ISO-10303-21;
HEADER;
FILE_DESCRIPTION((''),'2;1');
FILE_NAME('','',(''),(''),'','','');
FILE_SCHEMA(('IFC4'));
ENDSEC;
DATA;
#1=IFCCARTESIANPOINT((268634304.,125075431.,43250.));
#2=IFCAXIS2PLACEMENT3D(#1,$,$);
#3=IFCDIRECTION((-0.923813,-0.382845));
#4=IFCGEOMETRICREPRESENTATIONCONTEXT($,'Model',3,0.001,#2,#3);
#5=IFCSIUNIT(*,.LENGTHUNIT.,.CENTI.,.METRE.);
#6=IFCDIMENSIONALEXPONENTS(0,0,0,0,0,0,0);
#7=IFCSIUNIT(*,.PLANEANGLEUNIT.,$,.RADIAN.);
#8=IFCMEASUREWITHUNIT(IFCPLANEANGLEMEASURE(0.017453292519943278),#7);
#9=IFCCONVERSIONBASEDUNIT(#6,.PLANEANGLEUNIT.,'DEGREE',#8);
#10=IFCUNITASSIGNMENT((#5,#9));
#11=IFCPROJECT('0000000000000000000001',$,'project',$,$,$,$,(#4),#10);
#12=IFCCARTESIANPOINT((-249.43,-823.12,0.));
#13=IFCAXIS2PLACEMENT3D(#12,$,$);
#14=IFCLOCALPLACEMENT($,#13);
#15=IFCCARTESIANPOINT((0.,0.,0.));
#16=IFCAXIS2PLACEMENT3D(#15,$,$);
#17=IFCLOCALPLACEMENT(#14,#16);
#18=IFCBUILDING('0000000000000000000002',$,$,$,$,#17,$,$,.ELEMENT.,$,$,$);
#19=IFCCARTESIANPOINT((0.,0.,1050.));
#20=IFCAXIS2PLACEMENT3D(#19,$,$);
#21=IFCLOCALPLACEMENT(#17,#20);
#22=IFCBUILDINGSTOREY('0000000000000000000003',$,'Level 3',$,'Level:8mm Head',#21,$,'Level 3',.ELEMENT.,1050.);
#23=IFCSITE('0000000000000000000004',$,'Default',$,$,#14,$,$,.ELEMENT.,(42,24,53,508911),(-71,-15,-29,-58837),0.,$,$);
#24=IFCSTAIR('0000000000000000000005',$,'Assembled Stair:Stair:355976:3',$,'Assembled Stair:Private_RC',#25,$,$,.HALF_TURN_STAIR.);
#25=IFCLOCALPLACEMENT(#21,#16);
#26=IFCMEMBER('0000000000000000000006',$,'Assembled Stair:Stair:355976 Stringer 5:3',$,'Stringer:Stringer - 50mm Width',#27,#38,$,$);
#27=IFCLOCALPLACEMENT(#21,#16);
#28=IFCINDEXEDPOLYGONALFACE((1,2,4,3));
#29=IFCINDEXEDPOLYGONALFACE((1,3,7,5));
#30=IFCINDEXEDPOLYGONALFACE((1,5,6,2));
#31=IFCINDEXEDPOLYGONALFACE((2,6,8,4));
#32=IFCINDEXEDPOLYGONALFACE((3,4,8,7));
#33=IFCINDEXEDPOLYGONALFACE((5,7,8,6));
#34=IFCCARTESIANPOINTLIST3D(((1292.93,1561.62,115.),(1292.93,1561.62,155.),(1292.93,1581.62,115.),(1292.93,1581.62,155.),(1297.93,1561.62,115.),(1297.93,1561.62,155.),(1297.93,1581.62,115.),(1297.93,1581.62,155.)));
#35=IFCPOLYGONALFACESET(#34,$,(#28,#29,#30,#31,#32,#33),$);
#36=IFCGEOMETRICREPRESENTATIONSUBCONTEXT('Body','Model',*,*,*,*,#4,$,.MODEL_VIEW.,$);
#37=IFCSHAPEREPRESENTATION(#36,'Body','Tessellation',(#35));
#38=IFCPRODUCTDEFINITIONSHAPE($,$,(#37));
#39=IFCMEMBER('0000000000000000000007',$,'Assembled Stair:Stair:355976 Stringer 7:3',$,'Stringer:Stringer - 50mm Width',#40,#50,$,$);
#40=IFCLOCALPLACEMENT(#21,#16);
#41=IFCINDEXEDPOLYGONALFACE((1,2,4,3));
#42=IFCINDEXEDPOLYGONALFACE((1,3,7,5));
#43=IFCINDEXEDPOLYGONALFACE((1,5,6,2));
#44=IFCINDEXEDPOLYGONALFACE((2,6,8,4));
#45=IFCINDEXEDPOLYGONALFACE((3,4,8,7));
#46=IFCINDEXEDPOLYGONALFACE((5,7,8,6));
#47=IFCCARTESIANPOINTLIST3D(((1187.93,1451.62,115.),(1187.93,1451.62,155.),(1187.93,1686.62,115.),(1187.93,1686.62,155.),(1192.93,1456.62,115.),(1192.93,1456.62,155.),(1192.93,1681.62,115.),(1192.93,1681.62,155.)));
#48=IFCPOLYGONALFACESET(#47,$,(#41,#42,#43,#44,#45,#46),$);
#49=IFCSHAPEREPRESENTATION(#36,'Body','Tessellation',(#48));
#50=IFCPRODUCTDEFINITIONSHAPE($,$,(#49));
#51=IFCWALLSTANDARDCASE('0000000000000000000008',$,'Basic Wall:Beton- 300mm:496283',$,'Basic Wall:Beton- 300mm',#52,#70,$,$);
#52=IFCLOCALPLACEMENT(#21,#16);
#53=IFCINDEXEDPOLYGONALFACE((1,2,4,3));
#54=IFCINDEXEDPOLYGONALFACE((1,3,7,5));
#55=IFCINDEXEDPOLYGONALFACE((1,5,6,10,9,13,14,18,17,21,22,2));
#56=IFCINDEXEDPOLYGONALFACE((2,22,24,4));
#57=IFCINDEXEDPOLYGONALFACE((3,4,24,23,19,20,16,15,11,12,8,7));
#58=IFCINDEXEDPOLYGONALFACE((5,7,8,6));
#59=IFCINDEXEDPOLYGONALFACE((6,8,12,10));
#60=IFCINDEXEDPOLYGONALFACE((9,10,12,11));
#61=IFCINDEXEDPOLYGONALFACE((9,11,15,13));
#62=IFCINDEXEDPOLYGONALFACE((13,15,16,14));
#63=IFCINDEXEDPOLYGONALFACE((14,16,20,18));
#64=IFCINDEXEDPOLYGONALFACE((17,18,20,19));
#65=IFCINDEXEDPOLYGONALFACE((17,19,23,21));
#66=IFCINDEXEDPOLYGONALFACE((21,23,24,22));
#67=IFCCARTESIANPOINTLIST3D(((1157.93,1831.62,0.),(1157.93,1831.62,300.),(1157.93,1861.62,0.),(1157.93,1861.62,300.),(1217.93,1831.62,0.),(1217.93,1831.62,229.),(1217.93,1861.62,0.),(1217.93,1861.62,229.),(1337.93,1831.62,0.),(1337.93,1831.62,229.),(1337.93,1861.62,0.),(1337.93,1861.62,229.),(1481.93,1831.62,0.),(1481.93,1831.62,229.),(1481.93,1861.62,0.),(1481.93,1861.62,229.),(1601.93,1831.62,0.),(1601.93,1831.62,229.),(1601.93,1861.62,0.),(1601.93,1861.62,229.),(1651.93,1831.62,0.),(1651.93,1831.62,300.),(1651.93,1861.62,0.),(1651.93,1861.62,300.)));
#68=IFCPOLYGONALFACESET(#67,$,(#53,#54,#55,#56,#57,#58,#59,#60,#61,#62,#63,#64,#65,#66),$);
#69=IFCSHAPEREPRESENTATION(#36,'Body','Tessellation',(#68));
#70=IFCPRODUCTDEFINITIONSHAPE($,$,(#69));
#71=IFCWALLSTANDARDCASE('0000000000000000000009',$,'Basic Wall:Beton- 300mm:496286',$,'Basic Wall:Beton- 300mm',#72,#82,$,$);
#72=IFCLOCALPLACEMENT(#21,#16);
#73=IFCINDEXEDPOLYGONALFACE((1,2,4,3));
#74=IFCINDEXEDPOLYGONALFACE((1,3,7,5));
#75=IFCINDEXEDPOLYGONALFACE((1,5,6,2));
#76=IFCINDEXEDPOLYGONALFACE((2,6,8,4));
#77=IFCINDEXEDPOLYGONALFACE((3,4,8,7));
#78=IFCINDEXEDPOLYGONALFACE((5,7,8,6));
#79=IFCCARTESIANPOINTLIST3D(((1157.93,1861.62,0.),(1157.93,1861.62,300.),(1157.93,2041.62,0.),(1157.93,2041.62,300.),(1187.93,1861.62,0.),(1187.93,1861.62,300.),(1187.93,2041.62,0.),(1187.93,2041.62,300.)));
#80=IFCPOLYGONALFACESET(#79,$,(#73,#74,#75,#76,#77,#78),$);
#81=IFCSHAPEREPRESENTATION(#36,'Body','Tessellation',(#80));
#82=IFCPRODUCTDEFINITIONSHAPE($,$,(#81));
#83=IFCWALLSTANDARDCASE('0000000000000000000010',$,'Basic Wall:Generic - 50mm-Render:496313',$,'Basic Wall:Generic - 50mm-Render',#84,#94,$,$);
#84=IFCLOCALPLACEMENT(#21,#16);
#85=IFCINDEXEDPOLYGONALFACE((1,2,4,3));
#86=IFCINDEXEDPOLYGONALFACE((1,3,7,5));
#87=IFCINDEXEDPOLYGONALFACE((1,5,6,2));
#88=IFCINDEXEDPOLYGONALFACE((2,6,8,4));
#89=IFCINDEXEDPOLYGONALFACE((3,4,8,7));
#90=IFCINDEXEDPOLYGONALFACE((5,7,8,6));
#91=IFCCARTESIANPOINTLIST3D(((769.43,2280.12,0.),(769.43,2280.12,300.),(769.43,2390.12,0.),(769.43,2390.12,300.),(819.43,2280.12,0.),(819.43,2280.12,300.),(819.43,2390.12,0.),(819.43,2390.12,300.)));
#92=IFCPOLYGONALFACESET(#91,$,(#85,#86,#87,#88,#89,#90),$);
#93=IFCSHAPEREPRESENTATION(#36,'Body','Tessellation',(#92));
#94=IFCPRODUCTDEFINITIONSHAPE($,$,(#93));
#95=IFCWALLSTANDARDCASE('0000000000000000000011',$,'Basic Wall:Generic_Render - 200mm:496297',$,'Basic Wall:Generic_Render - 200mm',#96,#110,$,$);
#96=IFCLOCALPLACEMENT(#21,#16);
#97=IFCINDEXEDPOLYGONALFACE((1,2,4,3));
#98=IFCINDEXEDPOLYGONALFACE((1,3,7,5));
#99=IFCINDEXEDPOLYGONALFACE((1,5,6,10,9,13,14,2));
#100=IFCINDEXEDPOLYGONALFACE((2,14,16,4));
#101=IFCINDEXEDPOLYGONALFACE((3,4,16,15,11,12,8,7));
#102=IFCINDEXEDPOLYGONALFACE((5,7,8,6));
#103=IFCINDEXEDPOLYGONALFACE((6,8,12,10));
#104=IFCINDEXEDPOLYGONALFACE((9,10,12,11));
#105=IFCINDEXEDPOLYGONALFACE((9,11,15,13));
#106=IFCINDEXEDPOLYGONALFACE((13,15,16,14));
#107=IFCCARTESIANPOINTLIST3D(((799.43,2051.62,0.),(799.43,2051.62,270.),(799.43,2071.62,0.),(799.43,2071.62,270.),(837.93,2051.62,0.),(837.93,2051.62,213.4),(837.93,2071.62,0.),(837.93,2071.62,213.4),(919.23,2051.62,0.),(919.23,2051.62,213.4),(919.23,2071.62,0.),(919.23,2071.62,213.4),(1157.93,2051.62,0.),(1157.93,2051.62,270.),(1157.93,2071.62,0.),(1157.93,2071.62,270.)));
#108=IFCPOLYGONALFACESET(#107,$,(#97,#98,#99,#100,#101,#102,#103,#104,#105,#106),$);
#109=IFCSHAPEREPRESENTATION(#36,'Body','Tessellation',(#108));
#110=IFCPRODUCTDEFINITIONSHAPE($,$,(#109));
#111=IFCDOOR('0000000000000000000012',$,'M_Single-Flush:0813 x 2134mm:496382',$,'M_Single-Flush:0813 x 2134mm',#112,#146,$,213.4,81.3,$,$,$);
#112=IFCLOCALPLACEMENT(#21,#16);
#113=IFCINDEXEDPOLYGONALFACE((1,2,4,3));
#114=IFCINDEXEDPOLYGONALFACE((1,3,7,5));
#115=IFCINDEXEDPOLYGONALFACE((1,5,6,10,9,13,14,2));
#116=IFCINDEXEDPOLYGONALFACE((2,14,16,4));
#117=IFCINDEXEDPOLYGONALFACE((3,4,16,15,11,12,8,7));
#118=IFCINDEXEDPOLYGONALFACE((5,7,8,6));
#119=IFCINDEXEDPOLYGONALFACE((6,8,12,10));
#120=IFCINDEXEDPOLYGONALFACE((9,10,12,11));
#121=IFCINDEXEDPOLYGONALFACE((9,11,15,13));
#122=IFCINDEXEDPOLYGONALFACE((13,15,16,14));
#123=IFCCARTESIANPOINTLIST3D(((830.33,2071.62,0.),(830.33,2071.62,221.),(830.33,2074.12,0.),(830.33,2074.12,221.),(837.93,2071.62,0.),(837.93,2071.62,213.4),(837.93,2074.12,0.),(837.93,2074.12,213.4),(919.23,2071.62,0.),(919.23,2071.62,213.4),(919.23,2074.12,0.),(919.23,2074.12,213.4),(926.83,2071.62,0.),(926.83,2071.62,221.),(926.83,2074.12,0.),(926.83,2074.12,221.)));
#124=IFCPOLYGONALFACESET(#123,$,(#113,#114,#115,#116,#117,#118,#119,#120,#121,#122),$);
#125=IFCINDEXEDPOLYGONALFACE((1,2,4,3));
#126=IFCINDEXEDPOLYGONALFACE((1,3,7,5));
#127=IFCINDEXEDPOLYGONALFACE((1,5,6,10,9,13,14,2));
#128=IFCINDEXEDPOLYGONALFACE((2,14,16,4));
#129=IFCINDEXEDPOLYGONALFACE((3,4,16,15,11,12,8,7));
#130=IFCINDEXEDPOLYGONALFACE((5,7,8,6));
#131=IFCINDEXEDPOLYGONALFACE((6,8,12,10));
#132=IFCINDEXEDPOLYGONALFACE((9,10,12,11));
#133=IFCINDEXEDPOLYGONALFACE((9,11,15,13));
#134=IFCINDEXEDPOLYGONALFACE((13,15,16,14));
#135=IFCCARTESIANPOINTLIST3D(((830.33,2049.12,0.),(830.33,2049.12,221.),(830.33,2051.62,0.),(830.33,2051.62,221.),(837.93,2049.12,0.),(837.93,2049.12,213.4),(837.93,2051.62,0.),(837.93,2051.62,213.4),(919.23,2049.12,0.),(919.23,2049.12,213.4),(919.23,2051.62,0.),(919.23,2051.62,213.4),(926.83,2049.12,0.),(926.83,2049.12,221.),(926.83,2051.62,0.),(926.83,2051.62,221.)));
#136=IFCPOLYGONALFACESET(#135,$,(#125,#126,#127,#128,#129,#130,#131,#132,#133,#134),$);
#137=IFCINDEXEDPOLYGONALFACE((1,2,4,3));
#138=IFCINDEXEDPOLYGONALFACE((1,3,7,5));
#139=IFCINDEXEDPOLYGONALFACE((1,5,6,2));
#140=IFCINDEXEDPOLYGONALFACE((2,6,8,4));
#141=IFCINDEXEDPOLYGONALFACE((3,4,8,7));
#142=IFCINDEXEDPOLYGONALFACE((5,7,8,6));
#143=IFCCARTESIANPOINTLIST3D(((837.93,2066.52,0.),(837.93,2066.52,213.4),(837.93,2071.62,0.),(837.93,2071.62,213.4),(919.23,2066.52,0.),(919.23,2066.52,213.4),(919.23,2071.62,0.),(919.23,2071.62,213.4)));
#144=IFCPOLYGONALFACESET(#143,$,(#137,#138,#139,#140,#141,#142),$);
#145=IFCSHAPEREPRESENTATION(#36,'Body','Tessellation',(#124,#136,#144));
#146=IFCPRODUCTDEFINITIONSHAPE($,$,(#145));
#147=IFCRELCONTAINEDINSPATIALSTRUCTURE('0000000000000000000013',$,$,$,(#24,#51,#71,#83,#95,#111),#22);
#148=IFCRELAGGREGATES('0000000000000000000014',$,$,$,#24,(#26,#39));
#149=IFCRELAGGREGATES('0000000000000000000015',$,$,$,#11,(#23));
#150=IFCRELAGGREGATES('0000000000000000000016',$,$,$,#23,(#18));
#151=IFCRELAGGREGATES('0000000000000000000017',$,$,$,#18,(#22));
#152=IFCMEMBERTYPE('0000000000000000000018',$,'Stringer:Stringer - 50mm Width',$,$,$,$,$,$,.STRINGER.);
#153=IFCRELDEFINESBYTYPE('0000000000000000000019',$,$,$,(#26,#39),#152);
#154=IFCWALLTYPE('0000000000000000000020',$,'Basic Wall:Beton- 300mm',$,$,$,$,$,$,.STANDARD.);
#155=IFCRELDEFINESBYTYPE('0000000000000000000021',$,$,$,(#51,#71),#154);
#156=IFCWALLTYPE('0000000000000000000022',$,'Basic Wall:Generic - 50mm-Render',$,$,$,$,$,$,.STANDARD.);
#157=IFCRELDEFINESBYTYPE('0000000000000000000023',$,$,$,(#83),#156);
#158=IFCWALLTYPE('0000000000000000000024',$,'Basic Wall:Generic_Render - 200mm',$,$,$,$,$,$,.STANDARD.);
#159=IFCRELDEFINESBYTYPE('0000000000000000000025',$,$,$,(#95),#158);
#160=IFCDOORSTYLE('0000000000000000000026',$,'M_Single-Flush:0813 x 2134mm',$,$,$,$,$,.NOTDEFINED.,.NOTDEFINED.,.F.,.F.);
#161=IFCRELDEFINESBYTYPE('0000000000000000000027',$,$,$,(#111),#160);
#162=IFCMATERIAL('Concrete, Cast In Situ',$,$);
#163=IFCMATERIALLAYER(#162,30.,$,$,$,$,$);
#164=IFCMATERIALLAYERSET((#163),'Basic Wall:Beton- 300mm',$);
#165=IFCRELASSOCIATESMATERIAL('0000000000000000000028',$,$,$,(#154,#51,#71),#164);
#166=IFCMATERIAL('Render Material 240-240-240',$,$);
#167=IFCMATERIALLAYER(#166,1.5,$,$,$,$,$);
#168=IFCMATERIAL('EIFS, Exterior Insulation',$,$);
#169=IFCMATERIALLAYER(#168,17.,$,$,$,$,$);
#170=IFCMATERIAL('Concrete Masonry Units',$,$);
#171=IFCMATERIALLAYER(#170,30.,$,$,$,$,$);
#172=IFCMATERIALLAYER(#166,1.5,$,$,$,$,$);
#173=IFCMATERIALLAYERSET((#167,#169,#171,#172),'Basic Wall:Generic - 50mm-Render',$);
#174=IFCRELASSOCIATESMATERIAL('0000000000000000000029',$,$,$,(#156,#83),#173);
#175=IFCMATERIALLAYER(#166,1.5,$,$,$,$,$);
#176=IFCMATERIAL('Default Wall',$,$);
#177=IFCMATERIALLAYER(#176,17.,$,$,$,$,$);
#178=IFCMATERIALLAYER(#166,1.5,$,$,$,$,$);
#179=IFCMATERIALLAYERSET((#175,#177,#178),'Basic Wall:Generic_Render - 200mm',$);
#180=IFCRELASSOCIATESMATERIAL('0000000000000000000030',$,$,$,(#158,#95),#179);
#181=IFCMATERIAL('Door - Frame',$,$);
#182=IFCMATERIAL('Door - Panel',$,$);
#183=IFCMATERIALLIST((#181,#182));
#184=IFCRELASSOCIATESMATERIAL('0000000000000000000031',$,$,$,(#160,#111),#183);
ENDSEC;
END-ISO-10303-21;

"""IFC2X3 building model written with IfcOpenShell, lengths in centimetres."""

from ifc_helpers import new_model, entity, si_unit, converted_unit, direction, frame, frame_2d, origin, place, context, subcontext, project, spatial, polyline, rectangle, outline, extrude, source, transform, mapped, material, material_list, layer, layer_set, layer_usage, type_object, type_shapes, element, fill, aggregate, save


model = new_model("IFC2X3")

# Units and contexts
model_context = context("Model", 3, precision=0.001, world=frame((268634304.0, 125075431.0, 43250.0)), true_north=direction((-0.923813, -0.382845)))
body_context = subcontext(model_context, "Body", "Model", "MODEL_VIEW")
ifc_project = project(units=[si_unit("LENGTHUNIT", "METRE", prefix="CENTI"), converted_unit("PLANEANGLEUNIT", "DEGREE", entity("IfcPlaneAngleMeasure", 0.017453292519943278), si_unit("PLANEANGLEUNIT", "RADIAN"), dimensions=[0, 0, 0, 0, 0, 0, 0])], contexts=[model_context])

# Site, building, storey
site_placement = place(None, frame((-249.43, -823.12, 0.0)))
site = spatial("IfcSite", under=ifc_project, at=site_placement, Name="Default", CompositionType="ELEMENT", RefLatitude=(42, 24, 53, 508911), RefLongitude=(-71, -15, -29, -58837), RefElevation=0.0)
building_placement = place(site_placement, origin())
building = spatial("IfcBuilding", under=site, at=building_placement, CompositionType="ELEMENT")
storey_placement = place(building_placement, frame((0.0, 0.0, 1050.0)))
storey = spatial("IfcBuildingStorey", under=building, at=storey_placement, Name="Level 3", ObjectType="Level:8mm Head", LongName="Level 3", CompositionType="ELEMENT", Elevation=1050.0)

# Stair, members
stair_placement = place(storey_placement, origin())
stair = element("IfcStair", 1, at=stair_placement, inside=storey, Name="Assembled Stair:Stair:355976:3", ObjectType="Assembled Stair:Private_RC", ShapeType="HALF_TURN_STAIR")
member_type = type_object("IfcMemberType", Name="Stringer:Stringer - 50mm Width", PredefinedType="STRINGER")
member_1_placement = place(stair_placement, frame((1292.93, 1561.62, 115.0)))
member_1 = element("IfcMember", 2, at=member_1_placement, type_object=member_type, Name="Assembled Stair:Stair:355976 Stringer 5:3", ObjectType="Stringer:Stringer - 50mm Width", context=body_context, shape_type="SweptSolid", body=[
    extrude(rectangle(XDim=20.0, YDim=5.0, at=frame_2d((0.0, 0.0), x_axis=(1.0, 0.0))), frame((2.5, 10.0, 0.0), z_axis=(0.0, 0.0, 1.0), x_axis=(0.0, 1.0, 0.0)), (0.0, 0.0, 1.0), 40.0),
])
member_2_placement = place(stair_placement, frame((1187.93, 1451.62, 115.0)))
member_2 = element("IfcMember", 3, at=member_2_placement, type_object=member_type, Name="Assembled Stair:Stair:355976 Stringer 7:3", ObjectType="Stringer:Stringer - 50mm Width", context=body_context, shape_type="SweptSolid", body=[
    extrude(outline(polyline([(-117.5, -2.5), (117.5, -2.5), (112.5, 2.5), (-112.5, 2.5), (-117.5, -2.5)])), frame((2.5, 117.5, 0.0), z_axis=(0.0, 0.0, 1.0), x_axis=(0.0, -1.0, 0.0)), (0.0, 0.0, 1.0), 40.0),
])

# Wall, openings
ifc_material_1 = material(Name="Concrete, Cast In Situ")
ifc_layer_1 = layer(ifc_material_1, 30.0)
ifc_layer_set_1 = layer_set([ifc_layer_1], Name="Basic Wall:Beton- 300mm")
ifc_layer_usage_1 = layer_usage(ifc_layer_set_1, "AXIS2", "NEGATIVE", 15.0)
wall_type_1 = type_object("IfcWallType", Name="Basic Wall:Beton- 300mm", PredefinedType="STANDARD", material=ifc_layer_set_1)
wall_1_placement = place(storey_placement, frame((1157.93, 1846.62, 0.0)))
wall_1 = element("IfcWallStandardCase", 4, at=wall_1_placement, inside=storey, type_object=wall_type_1, material=ifc_layer_usage_1, Name="Basic Wall:Beton- 300mm:496283", ObjectType="Basic Wall:Beton- 300mm", context=body_context, shape_type="SweptSolid", body=[
    extrude(rectangle(XDim=494.0, YDim=30.0, at=frame_2d((247.0, 0.0), x_axis=(-1.0, 0.0))), origin(), (0.0, 0.0, 1.0), 300.0),
])
opening_1_placement = place(wall_1_placement, frame((60.0, -15.0, 0.0)))
element("IfcOpeningElement", 5, at=opening_1_placement, cuts=wall_1, ObjectType="Opening", context=body_context, shape_type="SweptSolid", body=[
    extrude(rectangle(XDim=120.0, YDim=229.0, at=frame_2d((114.5, 60.0), x_axis=(0.0, 1.0))), frame((0.0, 0.0, 0.0), z_axis=(0.0, 1.0, 0.0), x_axis=(0.0, 0.0, 1.0)), (0.0, 0.0, 1.0), 30.0),
])
opening_2_placement = place(wall_1_placement, frame((324.0, -15.0, 0.0)))
element("IfcOpeningElement", 6, at=opening_2_placement, cuts=wall_1, ObjectType="Opening", context=body_context, shape_type="SweptSolid", body=[
    extrude(rectangle(XDim=120.0, YDim=229.0, at=frame_2d((114.5, 60.0), x_axis=(0.0, 1.0))), frame((0.0, 0.0, 0.0), z_axis=(0.0, 1.0, 0.0), x_axis=(0.0, 0.0, 1.0)), (0.0, 0.0, 1.0), 30.0),
])

# Wall
ifc_layer_usage_2 = layer_usage(ifc_layer_set_1, "AXIS2", "POSITIVE", -15.0)
wall_2_placement = place(storey_placement, frame((1172.93, 2041.62, 0.0), z_axis=(0.0, 0.0, 1.0), x_axis=(0.0, -1.0, 0.0)))
element("IfcWallStandardCase", 7, at=wall_2_placement, inside=storey, type_object=wall_type_1, material=ifc_layer_usage_2, Name="Basic Wall:Beton- 300mm:496286", ObjectType="Basic Wall:Beton- 300mm", context=body_context, shape_type="SweptSolid", body=[
    extrude(rectangle(XDim=180.0, YDim=30.0, at=frame_2d((90.0, 0.0), x_axis=(-1.0, 0.0))), origin(), (0.0, 0.0, 1.0), 300.0),
])

# Wall
ifc_material_2 = material(Name="Render Material 240-240-240")
ifc_layer_2 = layer(ifc_material_2, 1.5)
ifc_material_3 = material(Name="EIFS, Exterior Insulation")
ifc_layer_3 = layer(ifc_material_3, 17.0)
ifc_material_4 = material(Name="Concrete Masonry Units")
ifc_layer_4 = layer(ifc_material_4, 30.0)
ifc_layer_5 = layer(ifc_material_2, 1.5)
ifc_layer_set_2 = layer_set([ifc_layer_2, ifc_layer_3, ifc_layer_4, ifc_layer_5], Name="Basic Wall:Generic - 50mm-Render")
ifc_layer_usage_3 = layer_usage(ifc_layer_set_2, "AXIS2", "NEGATIVE", 25.0)
wall_type_2 = type_object("IfcWallType", Name="Basic Wall:Generic - 50mm-Render", PredefinedType="STANDARD", material=ifc_layer_set_2)
wall_3_placement = place(storey_placement, frame((794.43, 2280.12, 0.0), z_axis=(0.0, 0.0, 1.0), x_axis=(0.0, 1.0, 0.0)))
element("IfcWallStandardCase", 8, at=wall_3_placement, inside=storey, type_object=wall_type_2, material=ifc_layer_usage_3, Name="Basic Wall:Generic - 50mm-Render:496313", ObjectType="Basic Wall:Generic - 50mm-Render", context=body_context, shape_type="SweptSolid", body=[
    extrude(rectangle(XDim=110.0, YDim=50.0, at=frame_2d((55.0, 0.0), x_axis=(-1.0, 0.0))), origin(), (0.0, 0.0, 1.0), 300.0),
])

# Wall, opening, door
ifc_layer_6 = layer(ifc_material_2, 1.5)
ifc_material_5 = material(Name="Default Wall")
ifc_layer_7 = layer(ifc_material_5, 17.0)
ifc_layer_8 = layer(ifc_material_2, 1.5)
ifc_layer_set_3 = layer_set([ifc_layer_6, ifc_layer_7, ifc_layer_8], Name="Basic Wall:Generic_Render - 200mm")
ifc_layer_usage_4 = layer_usage(ifc_layer_set_3, "AXIS2", "NEGATIVE", 10.0)
wall_type_3 = type_object("IfcWallType", Name="Basic Wall:Generic_Render - 200mm", PredefinedType="STANDARD", material=ifc_layer_set_3)
wall_4_placement = place(storey_placement, frame((1157.93, 2061.62, 0.0), z_axis=(0.0, 0.0, 1.0), x_axis=(-1.0, 0.0, 0.0)))
wall_4 = element("IfcWallStandardCase", 9, at=wall_4_placement, inside=storey, type_object=wall_type_3, material=ifc_layer_usage_4, Name="Basic Wall:Generic_Render - 200mm:496297", ObjectType="Basic Wall:Generic_Render - 200mm", context=body_context, shape_type="SweptSolid", body=[
    extrude(rectangle(XDim=358.5, YDim=20.0, at=frame_2d((179.25, 0.0), x_axis=(-1.0, 0.0))), origin(), (0.0, 0.0, 1.0), 270.0),
])
opening_3_placement = place(wall_4_placement, frame((320.0, 10.0, 0.0)))
opening_3 = element("IfcOpeningElement", 10, at=opening_3_placement, cuts=wall_4, ObjectType="Opening", context=body_context, shape_type="SweptSolid", body=[
    extrude(rectangle(XDim=81.3, YDim=213.4, at=frame_2d((106.7, 40.65), x_axis=(0.0, -1.0))), frame((0.0, 0.0, 0.0), z_axis=(0.0, -1.0, 0.0), x_axis=(0.0, 0.0, 1.0)), (0.0, 0.0, 1.0), 20.0),
])
ifc_material_6 = material(Name="Door - Frame")
ifc_material_7 = material(Name="Door - Panel")
ifc_material_list = material_list([ifc_material_6, ifc_material_7])
door_style_1 = type_object("IfcDoorStyle", Name="M_Single-Flush:0813 x 2134mm", ConstructionType="NOTDEFINED", OperationType="NOTDEFINED", ParameterTakesPrecedence=False, Sizeable=False, material=ifc_material_list)
shared_shape_1 = source(origin(), body_context, "Body", "SweptSolid", [
    extrude(outline(polyline([(-48.25, -112.4), (48.25, -112.4), (48.25, 108.6), (40.65, 108.6), (40.65, -104.8), (-40.65, -104.8), (-40.65, 108.6), (-48.25, 108.6), (-48.25, -112.4)])), frame((40.65, 22.5, 108.6), z_axis=(0.0, -1.0, 0.0), x_axis=(-1.0, 0.0, 0.0)), (0.0, 0.0, 1.0), 2.5),
    extrude(outline(polyline([(-112.4, -48.25), (108.6, -48.25), (108.6, -40.65), (-104.8, -40.65), (-104.8, 40.65), (108.6, 40.65), (108.6, 48.25), (-112.4, 48.25), (-112.4, -48.25)])), frame((40.65, 0.0, 108.6), z_axis=(0.0, -1.0, 0.0), x_axis=(0.0, 0.0, -1.0)), (0.0, 0.0, 1.0), 2.5),
    extrude(rectangle(XDim=81.3, YDim=5.1, at=frame_2d((0.0, 0.0), x_axis=(1.0, 0.0))), frame((40.65, 17.45, 0.0)), (0.0, 0.0, 1.0), 213.4),
])
type_shapes(door_style_1, [shared_shape_1])
door_1_placement = place(opening_3_placement, frame((0.0, 0.0, 0.0), z_axis=(0.0, 0.0, 1.0), x_axis=(-1.0, 0.0, 0.0)))
door_1 = element("IfcDoor", 11, at=door_1_placement, inside=storey, type_object=door_style_1, material=ifc_material_list, Name="M_Single-Flush:0813 x 2134mm:496382", ObjectType="M_Single-Flush:0813 x 2134mm", OverallHeight=213.4, OverallWidth=81.3, context=body_context, shape_type="MappedRepresentation", body=[
    mapped(shared_shape_1, transform((0.0, 0.0, 0.0), scale=1.0)),
])
fill(opening_3, door_1)

aggregate(stair, [member_1, member_2])

save(model, "model.ifc")
